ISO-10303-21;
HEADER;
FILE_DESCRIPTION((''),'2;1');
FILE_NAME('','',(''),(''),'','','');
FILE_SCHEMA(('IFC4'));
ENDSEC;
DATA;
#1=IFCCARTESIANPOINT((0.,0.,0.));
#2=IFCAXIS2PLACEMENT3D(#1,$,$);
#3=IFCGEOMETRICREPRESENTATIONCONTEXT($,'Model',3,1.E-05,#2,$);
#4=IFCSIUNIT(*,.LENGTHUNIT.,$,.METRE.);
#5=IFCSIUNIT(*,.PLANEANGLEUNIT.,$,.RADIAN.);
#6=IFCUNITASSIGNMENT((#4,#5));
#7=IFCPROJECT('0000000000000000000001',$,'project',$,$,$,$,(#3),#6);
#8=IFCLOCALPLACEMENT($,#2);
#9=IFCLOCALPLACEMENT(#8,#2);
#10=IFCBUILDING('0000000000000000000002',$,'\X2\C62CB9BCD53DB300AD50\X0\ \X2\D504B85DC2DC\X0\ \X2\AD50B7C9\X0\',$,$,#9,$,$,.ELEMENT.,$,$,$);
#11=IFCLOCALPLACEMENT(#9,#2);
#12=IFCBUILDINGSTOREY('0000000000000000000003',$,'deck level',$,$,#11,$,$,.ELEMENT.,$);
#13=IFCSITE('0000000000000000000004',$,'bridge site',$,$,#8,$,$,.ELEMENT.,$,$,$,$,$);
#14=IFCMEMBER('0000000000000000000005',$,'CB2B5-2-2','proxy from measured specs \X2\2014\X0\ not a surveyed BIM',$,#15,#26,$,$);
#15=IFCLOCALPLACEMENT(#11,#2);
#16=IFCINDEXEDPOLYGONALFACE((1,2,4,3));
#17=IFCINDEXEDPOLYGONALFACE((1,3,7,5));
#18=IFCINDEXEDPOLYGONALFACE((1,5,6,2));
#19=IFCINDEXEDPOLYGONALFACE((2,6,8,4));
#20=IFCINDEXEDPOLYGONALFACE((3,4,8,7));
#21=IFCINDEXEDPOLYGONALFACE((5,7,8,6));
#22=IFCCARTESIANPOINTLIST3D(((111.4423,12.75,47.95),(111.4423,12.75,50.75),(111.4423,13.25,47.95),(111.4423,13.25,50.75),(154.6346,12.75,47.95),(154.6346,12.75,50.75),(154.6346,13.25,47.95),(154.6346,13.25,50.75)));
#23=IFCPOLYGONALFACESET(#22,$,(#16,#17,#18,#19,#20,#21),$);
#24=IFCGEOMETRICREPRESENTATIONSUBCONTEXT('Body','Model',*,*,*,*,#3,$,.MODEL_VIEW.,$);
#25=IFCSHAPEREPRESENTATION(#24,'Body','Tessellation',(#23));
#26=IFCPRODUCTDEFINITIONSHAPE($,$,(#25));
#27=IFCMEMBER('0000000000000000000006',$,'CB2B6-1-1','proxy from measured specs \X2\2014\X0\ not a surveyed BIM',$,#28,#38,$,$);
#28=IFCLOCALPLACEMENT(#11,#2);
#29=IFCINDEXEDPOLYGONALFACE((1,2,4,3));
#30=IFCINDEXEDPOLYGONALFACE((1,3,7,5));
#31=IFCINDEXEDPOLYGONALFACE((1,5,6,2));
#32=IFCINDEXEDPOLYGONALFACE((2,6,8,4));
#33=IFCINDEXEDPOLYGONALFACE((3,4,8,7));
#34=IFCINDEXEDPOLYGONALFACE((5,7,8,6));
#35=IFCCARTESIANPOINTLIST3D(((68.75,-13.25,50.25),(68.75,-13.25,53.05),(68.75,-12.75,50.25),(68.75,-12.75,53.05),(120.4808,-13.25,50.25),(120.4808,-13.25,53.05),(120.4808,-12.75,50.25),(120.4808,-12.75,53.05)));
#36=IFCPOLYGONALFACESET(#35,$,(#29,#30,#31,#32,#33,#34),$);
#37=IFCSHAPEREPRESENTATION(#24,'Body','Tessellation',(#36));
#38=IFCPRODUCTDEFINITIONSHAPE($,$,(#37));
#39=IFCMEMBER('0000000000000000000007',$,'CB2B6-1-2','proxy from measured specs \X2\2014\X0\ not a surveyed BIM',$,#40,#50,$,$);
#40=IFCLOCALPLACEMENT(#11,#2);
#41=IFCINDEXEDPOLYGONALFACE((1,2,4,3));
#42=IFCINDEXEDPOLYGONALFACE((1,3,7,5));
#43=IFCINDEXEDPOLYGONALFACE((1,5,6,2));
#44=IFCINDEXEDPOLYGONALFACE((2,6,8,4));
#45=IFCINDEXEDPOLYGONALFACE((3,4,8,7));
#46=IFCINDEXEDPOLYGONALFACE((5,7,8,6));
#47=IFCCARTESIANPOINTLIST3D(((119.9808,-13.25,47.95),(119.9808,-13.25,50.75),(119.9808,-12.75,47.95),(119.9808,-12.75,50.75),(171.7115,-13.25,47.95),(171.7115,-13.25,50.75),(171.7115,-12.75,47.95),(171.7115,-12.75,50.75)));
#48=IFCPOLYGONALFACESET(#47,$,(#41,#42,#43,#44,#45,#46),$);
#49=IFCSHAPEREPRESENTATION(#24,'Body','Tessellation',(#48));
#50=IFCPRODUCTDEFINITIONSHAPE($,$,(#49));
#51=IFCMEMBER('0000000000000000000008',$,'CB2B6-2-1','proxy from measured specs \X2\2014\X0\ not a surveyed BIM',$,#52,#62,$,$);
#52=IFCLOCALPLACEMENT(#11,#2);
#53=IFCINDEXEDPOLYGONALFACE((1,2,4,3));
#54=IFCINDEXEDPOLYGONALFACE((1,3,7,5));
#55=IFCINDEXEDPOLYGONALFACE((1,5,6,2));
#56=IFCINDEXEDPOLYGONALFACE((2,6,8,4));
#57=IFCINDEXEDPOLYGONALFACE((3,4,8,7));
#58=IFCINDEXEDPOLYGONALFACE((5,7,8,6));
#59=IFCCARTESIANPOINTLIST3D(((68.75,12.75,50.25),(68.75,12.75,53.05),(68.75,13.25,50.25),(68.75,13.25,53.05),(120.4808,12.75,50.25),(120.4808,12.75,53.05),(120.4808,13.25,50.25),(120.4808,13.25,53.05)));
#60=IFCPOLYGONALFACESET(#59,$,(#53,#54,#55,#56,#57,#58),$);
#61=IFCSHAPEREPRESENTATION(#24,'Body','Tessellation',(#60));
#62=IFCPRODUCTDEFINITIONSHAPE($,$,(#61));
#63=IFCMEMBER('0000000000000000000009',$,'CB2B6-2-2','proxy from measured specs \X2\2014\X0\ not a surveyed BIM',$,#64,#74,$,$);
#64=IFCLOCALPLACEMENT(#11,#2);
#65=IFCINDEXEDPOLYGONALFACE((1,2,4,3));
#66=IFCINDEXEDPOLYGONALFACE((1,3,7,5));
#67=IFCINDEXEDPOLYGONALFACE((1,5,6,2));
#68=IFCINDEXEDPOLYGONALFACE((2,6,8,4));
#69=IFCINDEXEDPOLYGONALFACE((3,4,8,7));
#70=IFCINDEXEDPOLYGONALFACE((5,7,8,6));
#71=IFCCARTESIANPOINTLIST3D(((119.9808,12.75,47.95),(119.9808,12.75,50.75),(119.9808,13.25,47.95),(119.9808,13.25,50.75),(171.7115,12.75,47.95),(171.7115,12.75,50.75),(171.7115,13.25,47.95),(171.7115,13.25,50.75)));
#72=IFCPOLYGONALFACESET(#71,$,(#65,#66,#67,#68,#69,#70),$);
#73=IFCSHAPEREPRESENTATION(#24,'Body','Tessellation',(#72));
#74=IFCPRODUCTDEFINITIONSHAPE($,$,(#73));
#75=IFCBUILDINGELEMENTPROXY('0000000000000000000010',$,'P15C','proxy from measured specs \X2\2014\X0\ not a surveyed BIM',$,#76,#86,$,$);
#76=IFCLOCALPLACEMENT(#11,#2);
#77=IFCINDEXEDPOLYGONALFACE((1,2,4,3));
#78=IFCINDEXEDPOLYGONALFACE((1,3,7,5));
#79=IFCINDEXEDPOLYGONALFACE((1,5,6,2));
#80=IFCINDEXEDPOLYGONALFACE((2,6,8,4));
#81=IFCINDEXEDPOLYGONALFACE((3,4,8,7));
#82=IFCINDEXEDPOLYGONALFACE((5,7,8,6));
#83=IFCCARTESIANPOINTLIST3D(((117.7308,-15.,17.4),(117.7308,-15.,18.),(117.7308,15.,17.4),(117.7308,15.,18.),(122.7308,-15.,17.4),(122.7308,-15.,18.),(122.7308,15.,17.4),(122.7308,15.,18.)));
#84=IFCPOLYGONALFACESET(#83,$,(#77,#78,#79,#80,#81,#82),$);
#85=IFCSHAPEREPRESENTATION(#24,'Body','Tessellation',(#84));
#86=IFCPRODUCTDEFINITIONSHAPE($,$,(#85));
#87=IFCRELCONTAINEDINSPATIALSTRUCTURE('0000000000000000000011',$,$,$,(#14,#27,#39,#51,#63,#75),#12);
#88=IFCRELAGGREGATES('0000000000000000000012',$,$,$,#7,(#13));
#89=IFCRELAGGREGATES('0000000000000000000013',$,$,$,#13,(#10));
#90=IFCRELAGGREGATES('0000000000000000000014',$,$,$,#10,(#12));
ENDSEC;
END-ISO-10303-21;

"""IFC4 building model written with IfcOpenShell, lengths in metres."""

from ifc_helpers import new_model, si_unit, frame, origin, origin_2d, place, context, subcontext, project, spatial, rectangle, extrude, element, save


model = new_model("IFC4")

# Units and contexts
model_context = context("Model", 3, precision=1e-05, world=origin())
body_context = subcontext(model_context, "Body", "Model", "MODEL_VIEW")
ifc_project = project(units=[si_unit("LENGTHUNIT", "METRE"), si_unit("PLANEANGLEUNIT", "RADIAN")], contexts=[model_context])

# Site, building, storey
site_placement = place(None, origin())
site = spatial("IfcSite", under=ifc_project, at=site_placement, Name="bridge site", CompositionType="ELEMENT")
building_placement = place(site_placement, origin())
building = spatial("IfcBuilding", under=site, at=building_placement, Name="올림픽대교 프록시 교량", CompositionType="ELEMENT")
storey_placement = place(building_placement, origin())
storey = spatial("IfcBuildingStorey", under=building, at=storey_placement, Name="deck level", CompositionType="ELEMENT")

# Members
member_1_placement = place(storey_placement, frame((133.0385, 13.0, 47.95)))
element("IfcMember", 1, at=member_1_placement, inside=storey, Name="CB2B5-2-2", Description="proxy from measured specs — not a surveyed BIM", context=body_context, shape_type="SweptSolid", body=[
    extrude(rectangle(XDim=43.1923, YDim=0.5, at=origin_2d()), origin(), (0.0, 0.0, 1.0), 2.8),
])
member_2_placement = place(storey_placement, frame((94.6154, -13.0, 50.25)))
element("IfcMember", 2, at=member_2_placement, inside=storey, Name="CB2B6-1-1", Description="proxy from measured specs — not a surveyed BIM", context=body_context, shape_type="SweptSolid", body=[
    extrude(rectangle(XDim=51.7308, YDim=0.5, at=origin_2d()), origin(), (0.0, 0.0, 1.0), 2.8),
])
member_3_placement = place(storey_placement, frame((145.8462, -13.0, 47.95)))
element("IfcMember", 3, at=member_3_placement, inside=storey, Name="CB2B6-1-2", Description="proxy from measured specs — not a surveyed BIM", context=body_context, shape_type="SweptSolid", body=[
    extrude(rectangle(XDim=51.7308, YDim=0.5, at=origin_2d()), origin(), (0.0, 0.0, 1.0), 2.8),
])
member_4_placement = place(storey_placement, frame((94.6154, 13.0, 50.25)))
element("IfcMember", 4, at=member_4_placement, inside=storey, Name="CB2B6-2-1", Description="proxy from measured specs — not a surveyed BIM", context=body_context, shape_type="SweptSolid", body=[
    extrude(rectangle(XDim=51.7308, YDim=0.5, at=origin_2d()), origin(), (0.0, 0.0, 1.0), 2.8),
])
member_5_placement = place(storey_placement, frame((145.8462, 13.0, 47.95)))
element("IfcMember", 5, at=member_5_placement, inside=storey, Name="CB2B6-2-2", Description="proxy from measured specs — not a surveyed BIM", context=body_context, shape_type="SweptSolid", body=[
    extrude(rectangle(XDim=51.7308, YDim=0.5, at=origin_2d()), origin(), (0.0, 0.0, 1.0), 2.8),
])

# Building element proxy
proxy_placement = place(storey_placement, frame((120.2308, 0.0, 17.4)))
element("IfcBuildingElementProxy", 6, at=proxy_placement, inside=storey, Name="P15C", Description="proxy from measured specs — not a surveyed BIM", context=body_context, shape_type="SweptSolid", body=[
    extrude(rectangle(XDim=5.0, YDim=30.0, at=origin_2d()), origin(), (0.0, 0.0, 1.0), 0.6),
])

save(model, "model.ifc")
